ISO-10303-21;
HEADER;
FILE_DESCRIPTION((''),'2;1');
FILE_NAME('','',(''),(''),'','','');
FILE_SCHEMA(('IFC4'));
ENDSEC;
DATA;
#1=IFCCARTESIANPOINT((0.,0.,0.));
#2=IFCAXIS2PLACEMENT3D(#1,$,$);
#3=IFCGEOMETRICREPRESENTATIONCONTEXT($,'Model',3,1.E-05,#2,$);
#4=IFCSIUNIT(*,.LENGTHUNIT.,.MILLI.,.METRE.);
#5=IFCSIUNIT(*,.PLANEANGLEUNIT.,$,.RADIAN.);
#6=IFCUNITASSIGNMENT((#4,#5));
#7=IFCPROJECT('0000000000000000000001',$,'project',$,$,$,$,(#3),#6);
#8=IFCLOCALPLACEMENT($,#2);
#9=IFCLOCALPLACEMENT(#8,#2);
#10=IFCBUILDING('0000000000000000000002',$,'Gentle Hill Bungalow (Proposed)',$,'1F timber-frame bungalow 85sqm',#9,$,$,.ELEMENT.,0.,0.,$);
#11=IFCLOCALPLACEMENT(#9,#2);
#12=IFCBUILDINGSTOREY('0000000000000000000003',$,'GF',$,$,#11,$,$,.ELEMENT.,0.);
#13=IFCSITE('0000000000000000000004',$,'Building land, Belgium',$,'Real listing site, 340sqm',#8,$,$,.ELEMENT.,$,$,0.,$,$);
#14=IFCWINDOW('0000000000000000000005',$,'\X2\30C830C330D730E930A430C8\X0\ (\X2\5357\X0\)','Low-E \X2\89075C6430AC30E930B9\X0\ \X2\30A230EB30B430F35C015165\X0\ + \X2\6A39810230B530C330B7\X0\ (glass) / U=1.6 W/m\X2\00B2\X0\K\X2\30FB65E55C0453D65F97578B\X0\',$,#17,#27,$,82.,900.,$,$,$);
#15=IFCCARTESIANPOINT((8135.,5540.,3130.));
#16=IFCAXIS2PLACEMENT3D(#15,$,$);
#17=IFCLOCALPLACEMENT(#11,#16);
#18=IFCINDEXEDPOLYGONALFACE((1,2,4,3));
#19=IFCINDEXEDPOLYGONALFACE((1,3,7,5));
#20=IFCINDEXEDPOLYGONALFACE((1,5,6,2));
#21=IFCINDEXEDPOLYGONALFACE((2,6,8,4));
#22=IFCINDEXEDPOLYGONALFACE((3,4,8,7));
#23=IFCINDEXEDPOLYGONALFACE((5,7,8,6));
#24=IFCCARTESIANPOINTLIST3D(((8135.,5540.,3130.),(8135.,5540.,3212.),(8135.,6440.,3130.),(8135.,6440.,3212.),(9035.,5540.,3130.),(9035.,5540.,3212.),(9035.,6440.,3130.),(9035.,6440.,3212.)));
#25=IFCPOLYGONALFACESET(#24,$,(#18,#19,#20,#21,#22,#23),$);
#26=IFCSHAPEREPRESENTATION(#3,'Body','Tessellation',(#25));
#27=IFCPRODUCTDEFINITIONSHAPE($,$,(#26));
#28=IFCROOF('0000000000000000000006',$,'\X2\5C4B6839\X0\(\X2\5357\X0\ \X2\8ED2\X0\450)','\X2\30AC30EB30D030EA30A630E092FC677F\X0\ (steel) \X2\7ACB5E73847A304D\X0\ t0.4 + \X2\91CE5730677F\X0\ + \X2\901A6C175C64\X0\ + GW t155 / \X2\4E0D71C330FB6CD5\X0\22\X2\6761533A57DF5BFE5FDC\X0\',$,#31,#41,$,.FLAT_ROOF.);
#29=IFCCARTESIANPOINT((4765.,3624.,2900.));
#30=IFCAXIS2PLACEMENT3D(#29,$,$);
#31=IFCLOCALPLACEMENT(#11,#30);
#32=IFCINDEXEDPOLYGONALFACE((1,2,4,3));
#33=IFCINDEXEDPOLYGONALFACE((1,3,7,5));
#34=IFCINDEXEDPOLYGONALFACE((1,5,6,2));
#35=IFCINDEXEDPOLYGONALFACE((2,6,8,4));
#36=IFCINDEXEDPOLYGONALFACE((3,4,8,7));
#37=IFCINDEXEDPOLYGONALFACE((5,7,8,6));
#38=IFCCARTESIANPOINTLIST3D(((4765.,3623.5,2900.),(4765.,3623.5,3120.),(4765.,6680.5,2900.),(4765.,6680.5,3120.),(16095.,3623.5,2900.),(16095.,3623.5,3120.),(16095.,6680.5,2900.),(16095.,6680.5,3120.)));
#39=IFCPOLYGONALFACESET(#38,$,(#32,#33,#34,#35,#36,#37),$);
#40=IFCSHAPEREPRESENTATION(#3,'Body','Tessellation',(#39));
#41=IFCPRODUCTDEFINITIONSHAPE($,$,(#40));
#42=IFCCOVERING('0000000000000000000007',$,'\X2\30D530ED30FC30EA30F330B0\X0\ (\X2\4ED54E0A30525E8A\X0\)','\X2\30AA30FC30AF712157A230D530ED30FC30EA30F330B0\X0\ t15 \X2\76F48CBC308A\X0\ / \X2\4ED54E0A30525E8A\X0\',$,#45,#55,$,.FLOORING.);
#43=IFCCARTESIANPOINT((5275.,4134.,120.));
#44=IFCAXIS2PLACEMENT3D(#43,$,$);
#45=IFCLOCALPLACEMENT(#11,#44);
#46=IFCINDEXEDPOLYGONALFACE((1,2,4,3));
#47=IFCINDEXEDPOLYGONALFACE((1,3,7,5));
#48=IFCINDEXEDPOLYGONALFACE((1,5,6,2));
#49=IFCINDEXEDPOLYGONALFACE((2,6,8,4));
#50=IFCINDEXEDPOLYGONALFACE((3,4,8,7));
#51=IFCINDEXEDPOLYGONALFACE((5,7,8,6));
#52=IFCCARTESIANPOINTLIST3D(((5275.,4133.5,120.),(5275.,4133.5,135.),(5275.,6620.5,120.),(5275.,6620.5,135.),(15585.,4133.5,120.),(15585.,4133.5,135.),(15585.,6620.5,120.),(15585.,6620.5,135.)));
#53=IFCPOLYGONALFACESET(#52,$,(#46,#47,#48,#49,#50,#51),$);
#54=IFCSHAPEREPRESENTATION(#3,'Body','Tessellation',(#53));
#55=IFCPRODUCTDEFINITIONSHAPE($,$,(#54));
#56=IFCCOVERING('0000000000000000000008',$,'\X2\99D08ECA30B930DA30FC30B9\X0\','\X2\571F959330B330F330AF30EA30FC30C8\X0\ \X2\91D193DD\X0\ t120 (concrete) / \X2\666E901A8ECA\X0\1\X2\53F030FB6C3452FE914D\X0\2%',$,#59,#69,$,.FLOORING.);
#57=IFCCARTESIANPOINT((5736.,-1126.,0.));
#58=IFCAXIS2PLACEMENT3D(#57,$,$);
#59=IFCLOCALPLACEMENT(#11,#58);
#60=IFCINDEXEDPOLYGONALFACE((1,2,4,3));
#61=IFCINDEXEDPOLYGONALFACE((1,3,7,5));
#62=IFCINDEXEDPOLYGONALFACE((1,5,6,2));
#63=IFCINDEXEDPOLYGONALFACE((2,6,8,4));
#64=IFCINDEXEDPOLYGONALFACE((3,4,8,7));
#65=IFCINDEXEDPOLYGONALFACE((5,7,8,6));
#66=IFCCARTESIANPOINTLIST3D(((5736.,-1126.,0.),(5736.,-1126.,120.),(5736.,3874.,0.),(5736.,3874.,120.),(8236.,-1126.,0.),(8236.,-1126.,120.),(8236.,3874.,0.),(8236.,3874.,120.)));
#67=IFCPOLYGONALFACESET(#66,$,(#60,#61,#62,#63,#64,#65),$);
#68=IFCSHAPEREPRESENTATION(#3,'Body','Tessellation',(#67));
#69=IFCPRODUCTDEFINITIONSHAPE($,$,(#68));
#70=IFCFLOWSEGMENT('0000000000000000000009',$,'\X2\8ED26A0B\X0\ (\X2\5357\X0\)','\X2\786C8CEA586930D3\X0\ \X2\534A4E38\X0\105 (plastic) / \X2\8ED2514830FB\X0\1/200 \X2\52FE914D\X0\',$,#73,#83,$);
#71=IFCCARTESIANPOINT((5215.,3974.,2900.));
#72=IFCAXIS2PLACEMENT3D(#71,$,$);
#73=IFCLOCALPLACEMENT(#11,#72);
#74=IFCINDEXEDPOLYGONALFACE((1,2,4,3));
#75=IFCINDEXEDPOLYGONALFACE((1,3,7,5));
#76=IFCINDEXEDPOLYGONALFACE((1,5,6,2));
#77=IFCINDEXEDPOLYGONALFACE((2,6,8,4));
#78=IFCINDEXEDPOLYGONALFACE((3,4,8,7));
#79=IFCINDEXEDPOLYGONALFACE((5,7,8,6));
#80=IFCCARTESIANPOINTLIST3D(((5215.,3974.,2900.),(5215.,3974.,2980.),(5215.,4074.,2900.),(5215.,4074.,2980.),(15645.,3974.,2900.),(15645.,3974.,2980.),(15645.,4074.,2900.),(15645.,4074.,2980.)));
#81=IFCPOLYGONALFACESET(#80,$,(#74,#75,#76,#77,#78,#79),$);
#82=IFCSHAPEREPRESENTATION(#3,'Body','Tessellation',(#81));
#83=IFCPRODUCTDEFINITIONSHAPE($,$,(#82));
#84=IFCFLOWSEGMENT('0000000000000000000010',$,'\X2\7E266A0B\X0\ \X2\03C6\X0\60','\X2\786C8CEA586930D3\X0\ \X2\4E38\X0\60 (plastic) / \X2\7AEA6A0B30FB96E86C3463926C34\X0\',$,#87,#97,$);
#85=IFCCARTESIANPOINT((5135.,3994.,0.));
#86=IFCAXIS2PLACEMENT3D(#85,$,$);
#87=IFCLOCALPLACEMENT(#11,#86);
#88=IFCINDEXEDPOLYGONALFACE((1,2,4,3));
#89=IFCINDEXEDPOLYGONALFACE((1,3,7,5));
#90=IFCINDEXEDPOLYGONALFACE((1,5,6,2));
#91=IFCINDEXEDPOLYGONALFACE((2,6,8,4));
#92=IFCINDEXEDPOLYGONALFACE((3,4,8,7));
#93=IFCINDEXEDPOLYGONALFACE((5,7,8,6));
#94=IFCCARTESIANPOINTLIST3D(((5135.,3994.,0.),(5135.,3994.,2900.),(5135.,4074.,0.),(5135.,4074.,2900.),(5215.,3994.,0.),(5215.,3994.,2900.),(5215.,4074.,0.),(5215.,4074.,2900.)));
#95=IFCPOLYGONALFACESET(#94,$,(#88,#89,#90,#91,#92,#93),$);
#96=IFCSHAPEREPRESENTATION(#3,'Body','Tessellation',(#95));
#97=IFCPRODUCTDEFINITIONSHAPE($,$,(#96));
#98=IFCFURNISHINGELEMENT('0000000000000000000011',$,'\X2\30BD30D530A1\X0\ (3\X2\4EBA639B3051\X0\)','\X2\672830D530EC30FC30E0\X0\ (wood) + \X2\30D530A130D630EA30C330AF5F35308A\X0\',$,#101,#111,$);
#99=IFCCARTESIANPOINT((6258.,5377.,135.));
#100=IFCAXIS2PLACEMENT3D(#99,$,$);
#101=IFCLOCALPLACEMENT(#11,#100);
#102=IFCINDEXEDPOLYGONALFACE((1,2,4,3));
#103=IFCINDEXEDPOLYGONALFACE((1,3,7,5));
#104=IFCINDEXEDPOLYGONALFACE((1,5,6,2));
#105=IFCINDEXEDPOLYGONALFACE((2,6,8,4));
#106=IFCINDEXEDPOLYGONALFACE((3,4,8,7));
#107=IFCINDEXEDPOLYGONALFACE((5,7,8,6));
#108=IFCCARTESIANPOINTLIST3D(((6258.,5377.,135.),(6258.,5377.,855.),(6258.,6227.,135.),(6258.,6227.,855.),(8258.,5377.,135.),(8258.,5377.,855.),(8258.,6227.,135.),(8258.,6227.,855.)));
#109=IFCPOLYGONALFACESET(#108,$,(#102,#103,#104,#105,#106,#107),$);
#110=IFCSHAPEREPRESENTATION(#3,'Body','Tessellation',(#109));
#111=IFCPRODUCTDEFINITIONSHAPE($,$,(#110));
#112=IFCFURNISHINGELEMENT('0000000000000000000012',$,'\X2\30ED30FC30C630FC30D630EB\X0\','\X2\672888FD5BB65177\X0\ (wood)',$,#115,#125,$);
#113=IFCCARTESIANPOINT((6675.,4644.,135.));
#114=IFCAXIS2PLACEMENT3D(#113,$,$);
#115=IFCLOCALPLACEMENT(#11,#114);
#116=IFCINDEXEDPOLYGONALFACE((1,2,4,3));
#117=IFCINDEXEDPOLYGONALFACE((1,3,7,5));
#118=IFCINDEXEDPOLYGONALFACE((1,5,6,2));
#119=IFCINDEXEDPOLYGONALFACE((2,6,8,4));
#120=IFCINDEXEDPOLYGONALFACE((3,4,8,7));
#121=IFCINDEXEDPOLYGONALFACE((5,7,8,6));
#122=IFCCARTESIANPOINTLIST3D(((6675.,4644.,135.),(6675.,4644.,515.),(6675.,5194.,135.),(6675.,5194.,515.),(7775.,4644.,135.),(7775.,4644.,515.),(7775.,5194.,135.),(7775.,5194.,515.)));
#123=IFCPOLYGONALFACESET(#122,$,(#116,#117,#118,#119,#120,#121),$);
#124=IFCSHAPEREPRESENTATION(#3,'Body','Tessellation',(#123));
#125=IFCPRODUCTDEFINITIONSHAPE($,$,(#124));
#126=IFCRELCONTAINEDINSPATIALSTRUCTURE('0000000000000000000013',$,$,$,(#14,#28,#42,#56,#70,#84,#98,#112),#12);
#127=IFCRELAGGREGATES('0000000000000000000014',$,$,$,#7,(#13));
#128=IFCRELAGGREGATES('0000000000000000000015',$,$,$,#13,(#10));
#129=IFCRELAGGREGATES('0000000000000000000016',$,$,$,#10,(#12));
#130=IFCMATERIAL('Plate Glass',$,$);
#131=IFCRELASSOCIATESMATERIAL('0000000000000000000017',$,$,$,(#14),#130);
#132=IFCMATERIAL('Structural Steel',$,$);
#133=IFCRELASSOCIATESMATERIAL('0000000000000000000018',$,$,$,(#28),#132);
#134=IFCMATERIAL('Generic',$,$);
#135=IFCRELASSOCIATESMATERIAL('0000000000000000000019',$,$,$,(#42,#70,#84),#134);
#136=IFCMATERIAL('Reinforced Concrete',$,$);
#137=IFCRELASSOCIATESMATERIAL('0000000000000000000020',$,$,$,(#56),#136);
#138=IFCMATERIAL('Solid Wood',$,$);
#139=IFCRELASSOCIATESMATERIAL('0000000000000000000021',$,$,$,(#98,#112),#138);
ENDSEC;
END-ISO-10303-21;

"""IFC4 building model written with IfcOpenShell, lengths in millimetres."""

from ifc_helpers import new_model, si_unit, frame, frame_2d, origin, place, context, project, spatial, rectangle, extrude, material, element, save


model = new_model("IFC4")

# Units and contexts
model_context = context("Model", 3, precision=1e-05, world=origin())
ifc_project = project(units=[si_unit("LENGTHUNIT", "METRE", prefix="MILLI"), si_unit("PLANEANGLEUNIT", "RADIAN")], contexts=[model_context])

# Site, building, storey
site_placement = place(None, origin())
site = spatial("IfcSite", under=ifc_project, at=site_placement, Name="Building land, Belgium", ObjectType="Real listing site, 340sqm", CompositionType="ELEMENT", RefElevation=0.0)
building_placement = place(site_placement, origin())
building = spatial("IfcBuilding", under=site, at=building_placement, Name="Gentle Hill Bungalow (Proposed)", ObjectType="1F timber-frame bungalow 85sqm", CompositionType="ELEMENT", ElevationOfRefHeight=0.0, ElevationOfTerrain=0.0)
storey_placement = place(building_placement, origin())
storey = spatial("IfcBuildingStorey", under=building, at=storey_placement, Name="GF", CompositionType="ELEMENT", Elevation=0.0)

# Shared definitions
ifc_material_1 = material(Name="Solid Wood")

# Shared definitions
ifc_material_2 = material(Name="Reinforced Concrete")

# Shared definitions
ifc_material_3 = material(Name="Plate Glass")

# Window
window_1_placement = place(storey_placement, frame((8135.0, 5540.0, 3130.0)))
element("IfcWindow", 1, at=window_1_placement, inside=storey, material=ifc_material_3, Name="トップライト (南)", Description="Low-E 複層ガラス アルゴン封入 + 樹脂サッシ (glass) / U=1.6 W/m²K・日射取得型", OverallHeight=82.0, OverallWidth=900.0, context=model_context, shape_type="SweptSolid", body=[
    extrude(rectangle(XDim=900.0, YDim=900.0, at=frame_2d((450.0, 450.0))), frame((8135.0, 5540.0, 3130.0)), (0.0, 0.0, 1.0), 82.0),
])

# Roof
ifc_material_4 = material(Name="Structural Steel")
roof_1_placement = place(storey_placement, frame((4765.0, 3624.0, 2900.0)))
element("IfcRoof", 2, at=roof_1_placement, inside=storey, material=ifc_material_4, Name="屋根(南 軒450)", Description="ガルバリウム鋼板 (steel) 立平葺き t0.4 + 野地板 + 通気層 + GW t155 / 不燃・法22条区域対応", PredefinedType="FLAT_ROOF", context=model_context, shape_type="SweptSolid", body=[
    extrude(rectangle(XDim=11330.0, YDim=3057.0, at=frame_2d((5665.0, 1528.0))), frame((4765.0, 3624.0, 2900.0)), (0.0, 0.0, 1.0), 220.0),
])

# Coverings
ifc_material_5 = material(Name="Generic")
covering_1_placement = place(storey_placement, frame((5275.0, 4134.0, 120.0)))
element("IfcCovering", 3, at=covering_1_placement, inside=storey, material=ifc_material_5, Name="フローリング (仕上げ床)", Description="オーク無垢フローリング t15 直貼り / 仕上げ床", PredefinedType="FLOORING", context=model_context, shape_type="SweptSolid", body=[
    extrude(rectangle(XDim=10310.0, YDim=2487.0, at=frame_2d((5155.0, 1243.0))), frame((5275.0, 4134.0, 120.0)), (0.0, 0.0, 1.0), 15.0),
])
covering_2_placement = place(storey_placement, frame((5736.0, -1126.0, 0.0)))
element("IfcCovering", 4, at=covering_2_placement, inside=storey, material=ifc_material_2, Name="駐車スペース", Description="土間コンクリート 金鏝 t120 (concrete) / 普通車1台・水勾配2%", PredefinedType="FLOORING", context=model_context, shape_type="SweptSolid", body=[
    extrude(rectangle(XDim=2500.0, YDim=5000.0, at=frame_2d((1250.0, 2500.0))), frame((5736.0, -1126.0, 0.0)), (0.0, 0.0, 1.0), 120.0),
])

# Flow segments
flow_segment_1_placement = place(storey_placement, frame((5215.0, 3974.0, 2900.0)))
element("IfcFlowSegment", 5, at=flow_segment_1_placement, inside=storey, material=ifc_material_5, Name="軒樋 (南)", Description="硬質塩ビ 半丸105 (plastic) / 軒先・1/200 勾配", context=model_context, shape_type="SweptSolid", body=[
    extrude(rectangle(XDim=10430.0, YDim=100.0, at=frame_2d((5215.0, 50.0))), frame((5215.0, 3974.0, 2900.0)), (0.0, 0.0, 1.0), 80.0),
])
flow_segment_2_placement = place(storey_placement, frame((5135.0, 3994.0, 0.0)))
element("IfcFlowSegment", 6, at=flow_segment_2_placement, inside=storey, material=ifc_material_5, Name="縦樋 φ60", Description="硬質塩ビ 丸60 (plastic) / 竪樋・雨水排水", context=model_context, shape_type="SweptSolid", body=[
    extrude(rectangle(XDim=80.0, YDim=80.0, at=frame_2d((40.0, 40.0))), frame((5135.0, 3994.0, 0.0)), (0.0, 0.0, 1.0), 2900.0),
])

# Furnishing elements
furnishing_1_placement = place(storey_placement, frame((6258.0, 5377.0, 135.0)))
element("IfcFurnishingElement", 7, at=furnishing_1_placement, inside=storey, material=ifc_material_1, Name="ソファ (3人掛け)", Description="木フレーム (wood) + ファブリック張り", context=model_context, shape_type="SweptSolid", body=[
    extrude(rectangle(XDim=2000.0, YDim=850.0, at=frame_2d((1000.0, 425.0))), frame((6258.0, 5377.0, 135.0)), (0.0, 0.0, 1.0), 720.0),
])
furnishing_2_placement = place(storey_placement, frame((6675.0, 4644.0, 135.0)))
element("IfcFurnishingElement", 8, at=furnishing_2_placement, inside=storey, material=ifc_material_1, Name="ローテーブル", Description="木製家具 (wood)", context=model_context, shape_type="SweptSolid", body=[
    extrude(rectangle(XDim=1100.0, YDim=550.0, at=frame_2d((550.0, 275.0))), frame((6675.0, 4644.0, 135.0)), (0.0, 0.0, 1.0), 380.0),
])

save(model, "model.ifc")
